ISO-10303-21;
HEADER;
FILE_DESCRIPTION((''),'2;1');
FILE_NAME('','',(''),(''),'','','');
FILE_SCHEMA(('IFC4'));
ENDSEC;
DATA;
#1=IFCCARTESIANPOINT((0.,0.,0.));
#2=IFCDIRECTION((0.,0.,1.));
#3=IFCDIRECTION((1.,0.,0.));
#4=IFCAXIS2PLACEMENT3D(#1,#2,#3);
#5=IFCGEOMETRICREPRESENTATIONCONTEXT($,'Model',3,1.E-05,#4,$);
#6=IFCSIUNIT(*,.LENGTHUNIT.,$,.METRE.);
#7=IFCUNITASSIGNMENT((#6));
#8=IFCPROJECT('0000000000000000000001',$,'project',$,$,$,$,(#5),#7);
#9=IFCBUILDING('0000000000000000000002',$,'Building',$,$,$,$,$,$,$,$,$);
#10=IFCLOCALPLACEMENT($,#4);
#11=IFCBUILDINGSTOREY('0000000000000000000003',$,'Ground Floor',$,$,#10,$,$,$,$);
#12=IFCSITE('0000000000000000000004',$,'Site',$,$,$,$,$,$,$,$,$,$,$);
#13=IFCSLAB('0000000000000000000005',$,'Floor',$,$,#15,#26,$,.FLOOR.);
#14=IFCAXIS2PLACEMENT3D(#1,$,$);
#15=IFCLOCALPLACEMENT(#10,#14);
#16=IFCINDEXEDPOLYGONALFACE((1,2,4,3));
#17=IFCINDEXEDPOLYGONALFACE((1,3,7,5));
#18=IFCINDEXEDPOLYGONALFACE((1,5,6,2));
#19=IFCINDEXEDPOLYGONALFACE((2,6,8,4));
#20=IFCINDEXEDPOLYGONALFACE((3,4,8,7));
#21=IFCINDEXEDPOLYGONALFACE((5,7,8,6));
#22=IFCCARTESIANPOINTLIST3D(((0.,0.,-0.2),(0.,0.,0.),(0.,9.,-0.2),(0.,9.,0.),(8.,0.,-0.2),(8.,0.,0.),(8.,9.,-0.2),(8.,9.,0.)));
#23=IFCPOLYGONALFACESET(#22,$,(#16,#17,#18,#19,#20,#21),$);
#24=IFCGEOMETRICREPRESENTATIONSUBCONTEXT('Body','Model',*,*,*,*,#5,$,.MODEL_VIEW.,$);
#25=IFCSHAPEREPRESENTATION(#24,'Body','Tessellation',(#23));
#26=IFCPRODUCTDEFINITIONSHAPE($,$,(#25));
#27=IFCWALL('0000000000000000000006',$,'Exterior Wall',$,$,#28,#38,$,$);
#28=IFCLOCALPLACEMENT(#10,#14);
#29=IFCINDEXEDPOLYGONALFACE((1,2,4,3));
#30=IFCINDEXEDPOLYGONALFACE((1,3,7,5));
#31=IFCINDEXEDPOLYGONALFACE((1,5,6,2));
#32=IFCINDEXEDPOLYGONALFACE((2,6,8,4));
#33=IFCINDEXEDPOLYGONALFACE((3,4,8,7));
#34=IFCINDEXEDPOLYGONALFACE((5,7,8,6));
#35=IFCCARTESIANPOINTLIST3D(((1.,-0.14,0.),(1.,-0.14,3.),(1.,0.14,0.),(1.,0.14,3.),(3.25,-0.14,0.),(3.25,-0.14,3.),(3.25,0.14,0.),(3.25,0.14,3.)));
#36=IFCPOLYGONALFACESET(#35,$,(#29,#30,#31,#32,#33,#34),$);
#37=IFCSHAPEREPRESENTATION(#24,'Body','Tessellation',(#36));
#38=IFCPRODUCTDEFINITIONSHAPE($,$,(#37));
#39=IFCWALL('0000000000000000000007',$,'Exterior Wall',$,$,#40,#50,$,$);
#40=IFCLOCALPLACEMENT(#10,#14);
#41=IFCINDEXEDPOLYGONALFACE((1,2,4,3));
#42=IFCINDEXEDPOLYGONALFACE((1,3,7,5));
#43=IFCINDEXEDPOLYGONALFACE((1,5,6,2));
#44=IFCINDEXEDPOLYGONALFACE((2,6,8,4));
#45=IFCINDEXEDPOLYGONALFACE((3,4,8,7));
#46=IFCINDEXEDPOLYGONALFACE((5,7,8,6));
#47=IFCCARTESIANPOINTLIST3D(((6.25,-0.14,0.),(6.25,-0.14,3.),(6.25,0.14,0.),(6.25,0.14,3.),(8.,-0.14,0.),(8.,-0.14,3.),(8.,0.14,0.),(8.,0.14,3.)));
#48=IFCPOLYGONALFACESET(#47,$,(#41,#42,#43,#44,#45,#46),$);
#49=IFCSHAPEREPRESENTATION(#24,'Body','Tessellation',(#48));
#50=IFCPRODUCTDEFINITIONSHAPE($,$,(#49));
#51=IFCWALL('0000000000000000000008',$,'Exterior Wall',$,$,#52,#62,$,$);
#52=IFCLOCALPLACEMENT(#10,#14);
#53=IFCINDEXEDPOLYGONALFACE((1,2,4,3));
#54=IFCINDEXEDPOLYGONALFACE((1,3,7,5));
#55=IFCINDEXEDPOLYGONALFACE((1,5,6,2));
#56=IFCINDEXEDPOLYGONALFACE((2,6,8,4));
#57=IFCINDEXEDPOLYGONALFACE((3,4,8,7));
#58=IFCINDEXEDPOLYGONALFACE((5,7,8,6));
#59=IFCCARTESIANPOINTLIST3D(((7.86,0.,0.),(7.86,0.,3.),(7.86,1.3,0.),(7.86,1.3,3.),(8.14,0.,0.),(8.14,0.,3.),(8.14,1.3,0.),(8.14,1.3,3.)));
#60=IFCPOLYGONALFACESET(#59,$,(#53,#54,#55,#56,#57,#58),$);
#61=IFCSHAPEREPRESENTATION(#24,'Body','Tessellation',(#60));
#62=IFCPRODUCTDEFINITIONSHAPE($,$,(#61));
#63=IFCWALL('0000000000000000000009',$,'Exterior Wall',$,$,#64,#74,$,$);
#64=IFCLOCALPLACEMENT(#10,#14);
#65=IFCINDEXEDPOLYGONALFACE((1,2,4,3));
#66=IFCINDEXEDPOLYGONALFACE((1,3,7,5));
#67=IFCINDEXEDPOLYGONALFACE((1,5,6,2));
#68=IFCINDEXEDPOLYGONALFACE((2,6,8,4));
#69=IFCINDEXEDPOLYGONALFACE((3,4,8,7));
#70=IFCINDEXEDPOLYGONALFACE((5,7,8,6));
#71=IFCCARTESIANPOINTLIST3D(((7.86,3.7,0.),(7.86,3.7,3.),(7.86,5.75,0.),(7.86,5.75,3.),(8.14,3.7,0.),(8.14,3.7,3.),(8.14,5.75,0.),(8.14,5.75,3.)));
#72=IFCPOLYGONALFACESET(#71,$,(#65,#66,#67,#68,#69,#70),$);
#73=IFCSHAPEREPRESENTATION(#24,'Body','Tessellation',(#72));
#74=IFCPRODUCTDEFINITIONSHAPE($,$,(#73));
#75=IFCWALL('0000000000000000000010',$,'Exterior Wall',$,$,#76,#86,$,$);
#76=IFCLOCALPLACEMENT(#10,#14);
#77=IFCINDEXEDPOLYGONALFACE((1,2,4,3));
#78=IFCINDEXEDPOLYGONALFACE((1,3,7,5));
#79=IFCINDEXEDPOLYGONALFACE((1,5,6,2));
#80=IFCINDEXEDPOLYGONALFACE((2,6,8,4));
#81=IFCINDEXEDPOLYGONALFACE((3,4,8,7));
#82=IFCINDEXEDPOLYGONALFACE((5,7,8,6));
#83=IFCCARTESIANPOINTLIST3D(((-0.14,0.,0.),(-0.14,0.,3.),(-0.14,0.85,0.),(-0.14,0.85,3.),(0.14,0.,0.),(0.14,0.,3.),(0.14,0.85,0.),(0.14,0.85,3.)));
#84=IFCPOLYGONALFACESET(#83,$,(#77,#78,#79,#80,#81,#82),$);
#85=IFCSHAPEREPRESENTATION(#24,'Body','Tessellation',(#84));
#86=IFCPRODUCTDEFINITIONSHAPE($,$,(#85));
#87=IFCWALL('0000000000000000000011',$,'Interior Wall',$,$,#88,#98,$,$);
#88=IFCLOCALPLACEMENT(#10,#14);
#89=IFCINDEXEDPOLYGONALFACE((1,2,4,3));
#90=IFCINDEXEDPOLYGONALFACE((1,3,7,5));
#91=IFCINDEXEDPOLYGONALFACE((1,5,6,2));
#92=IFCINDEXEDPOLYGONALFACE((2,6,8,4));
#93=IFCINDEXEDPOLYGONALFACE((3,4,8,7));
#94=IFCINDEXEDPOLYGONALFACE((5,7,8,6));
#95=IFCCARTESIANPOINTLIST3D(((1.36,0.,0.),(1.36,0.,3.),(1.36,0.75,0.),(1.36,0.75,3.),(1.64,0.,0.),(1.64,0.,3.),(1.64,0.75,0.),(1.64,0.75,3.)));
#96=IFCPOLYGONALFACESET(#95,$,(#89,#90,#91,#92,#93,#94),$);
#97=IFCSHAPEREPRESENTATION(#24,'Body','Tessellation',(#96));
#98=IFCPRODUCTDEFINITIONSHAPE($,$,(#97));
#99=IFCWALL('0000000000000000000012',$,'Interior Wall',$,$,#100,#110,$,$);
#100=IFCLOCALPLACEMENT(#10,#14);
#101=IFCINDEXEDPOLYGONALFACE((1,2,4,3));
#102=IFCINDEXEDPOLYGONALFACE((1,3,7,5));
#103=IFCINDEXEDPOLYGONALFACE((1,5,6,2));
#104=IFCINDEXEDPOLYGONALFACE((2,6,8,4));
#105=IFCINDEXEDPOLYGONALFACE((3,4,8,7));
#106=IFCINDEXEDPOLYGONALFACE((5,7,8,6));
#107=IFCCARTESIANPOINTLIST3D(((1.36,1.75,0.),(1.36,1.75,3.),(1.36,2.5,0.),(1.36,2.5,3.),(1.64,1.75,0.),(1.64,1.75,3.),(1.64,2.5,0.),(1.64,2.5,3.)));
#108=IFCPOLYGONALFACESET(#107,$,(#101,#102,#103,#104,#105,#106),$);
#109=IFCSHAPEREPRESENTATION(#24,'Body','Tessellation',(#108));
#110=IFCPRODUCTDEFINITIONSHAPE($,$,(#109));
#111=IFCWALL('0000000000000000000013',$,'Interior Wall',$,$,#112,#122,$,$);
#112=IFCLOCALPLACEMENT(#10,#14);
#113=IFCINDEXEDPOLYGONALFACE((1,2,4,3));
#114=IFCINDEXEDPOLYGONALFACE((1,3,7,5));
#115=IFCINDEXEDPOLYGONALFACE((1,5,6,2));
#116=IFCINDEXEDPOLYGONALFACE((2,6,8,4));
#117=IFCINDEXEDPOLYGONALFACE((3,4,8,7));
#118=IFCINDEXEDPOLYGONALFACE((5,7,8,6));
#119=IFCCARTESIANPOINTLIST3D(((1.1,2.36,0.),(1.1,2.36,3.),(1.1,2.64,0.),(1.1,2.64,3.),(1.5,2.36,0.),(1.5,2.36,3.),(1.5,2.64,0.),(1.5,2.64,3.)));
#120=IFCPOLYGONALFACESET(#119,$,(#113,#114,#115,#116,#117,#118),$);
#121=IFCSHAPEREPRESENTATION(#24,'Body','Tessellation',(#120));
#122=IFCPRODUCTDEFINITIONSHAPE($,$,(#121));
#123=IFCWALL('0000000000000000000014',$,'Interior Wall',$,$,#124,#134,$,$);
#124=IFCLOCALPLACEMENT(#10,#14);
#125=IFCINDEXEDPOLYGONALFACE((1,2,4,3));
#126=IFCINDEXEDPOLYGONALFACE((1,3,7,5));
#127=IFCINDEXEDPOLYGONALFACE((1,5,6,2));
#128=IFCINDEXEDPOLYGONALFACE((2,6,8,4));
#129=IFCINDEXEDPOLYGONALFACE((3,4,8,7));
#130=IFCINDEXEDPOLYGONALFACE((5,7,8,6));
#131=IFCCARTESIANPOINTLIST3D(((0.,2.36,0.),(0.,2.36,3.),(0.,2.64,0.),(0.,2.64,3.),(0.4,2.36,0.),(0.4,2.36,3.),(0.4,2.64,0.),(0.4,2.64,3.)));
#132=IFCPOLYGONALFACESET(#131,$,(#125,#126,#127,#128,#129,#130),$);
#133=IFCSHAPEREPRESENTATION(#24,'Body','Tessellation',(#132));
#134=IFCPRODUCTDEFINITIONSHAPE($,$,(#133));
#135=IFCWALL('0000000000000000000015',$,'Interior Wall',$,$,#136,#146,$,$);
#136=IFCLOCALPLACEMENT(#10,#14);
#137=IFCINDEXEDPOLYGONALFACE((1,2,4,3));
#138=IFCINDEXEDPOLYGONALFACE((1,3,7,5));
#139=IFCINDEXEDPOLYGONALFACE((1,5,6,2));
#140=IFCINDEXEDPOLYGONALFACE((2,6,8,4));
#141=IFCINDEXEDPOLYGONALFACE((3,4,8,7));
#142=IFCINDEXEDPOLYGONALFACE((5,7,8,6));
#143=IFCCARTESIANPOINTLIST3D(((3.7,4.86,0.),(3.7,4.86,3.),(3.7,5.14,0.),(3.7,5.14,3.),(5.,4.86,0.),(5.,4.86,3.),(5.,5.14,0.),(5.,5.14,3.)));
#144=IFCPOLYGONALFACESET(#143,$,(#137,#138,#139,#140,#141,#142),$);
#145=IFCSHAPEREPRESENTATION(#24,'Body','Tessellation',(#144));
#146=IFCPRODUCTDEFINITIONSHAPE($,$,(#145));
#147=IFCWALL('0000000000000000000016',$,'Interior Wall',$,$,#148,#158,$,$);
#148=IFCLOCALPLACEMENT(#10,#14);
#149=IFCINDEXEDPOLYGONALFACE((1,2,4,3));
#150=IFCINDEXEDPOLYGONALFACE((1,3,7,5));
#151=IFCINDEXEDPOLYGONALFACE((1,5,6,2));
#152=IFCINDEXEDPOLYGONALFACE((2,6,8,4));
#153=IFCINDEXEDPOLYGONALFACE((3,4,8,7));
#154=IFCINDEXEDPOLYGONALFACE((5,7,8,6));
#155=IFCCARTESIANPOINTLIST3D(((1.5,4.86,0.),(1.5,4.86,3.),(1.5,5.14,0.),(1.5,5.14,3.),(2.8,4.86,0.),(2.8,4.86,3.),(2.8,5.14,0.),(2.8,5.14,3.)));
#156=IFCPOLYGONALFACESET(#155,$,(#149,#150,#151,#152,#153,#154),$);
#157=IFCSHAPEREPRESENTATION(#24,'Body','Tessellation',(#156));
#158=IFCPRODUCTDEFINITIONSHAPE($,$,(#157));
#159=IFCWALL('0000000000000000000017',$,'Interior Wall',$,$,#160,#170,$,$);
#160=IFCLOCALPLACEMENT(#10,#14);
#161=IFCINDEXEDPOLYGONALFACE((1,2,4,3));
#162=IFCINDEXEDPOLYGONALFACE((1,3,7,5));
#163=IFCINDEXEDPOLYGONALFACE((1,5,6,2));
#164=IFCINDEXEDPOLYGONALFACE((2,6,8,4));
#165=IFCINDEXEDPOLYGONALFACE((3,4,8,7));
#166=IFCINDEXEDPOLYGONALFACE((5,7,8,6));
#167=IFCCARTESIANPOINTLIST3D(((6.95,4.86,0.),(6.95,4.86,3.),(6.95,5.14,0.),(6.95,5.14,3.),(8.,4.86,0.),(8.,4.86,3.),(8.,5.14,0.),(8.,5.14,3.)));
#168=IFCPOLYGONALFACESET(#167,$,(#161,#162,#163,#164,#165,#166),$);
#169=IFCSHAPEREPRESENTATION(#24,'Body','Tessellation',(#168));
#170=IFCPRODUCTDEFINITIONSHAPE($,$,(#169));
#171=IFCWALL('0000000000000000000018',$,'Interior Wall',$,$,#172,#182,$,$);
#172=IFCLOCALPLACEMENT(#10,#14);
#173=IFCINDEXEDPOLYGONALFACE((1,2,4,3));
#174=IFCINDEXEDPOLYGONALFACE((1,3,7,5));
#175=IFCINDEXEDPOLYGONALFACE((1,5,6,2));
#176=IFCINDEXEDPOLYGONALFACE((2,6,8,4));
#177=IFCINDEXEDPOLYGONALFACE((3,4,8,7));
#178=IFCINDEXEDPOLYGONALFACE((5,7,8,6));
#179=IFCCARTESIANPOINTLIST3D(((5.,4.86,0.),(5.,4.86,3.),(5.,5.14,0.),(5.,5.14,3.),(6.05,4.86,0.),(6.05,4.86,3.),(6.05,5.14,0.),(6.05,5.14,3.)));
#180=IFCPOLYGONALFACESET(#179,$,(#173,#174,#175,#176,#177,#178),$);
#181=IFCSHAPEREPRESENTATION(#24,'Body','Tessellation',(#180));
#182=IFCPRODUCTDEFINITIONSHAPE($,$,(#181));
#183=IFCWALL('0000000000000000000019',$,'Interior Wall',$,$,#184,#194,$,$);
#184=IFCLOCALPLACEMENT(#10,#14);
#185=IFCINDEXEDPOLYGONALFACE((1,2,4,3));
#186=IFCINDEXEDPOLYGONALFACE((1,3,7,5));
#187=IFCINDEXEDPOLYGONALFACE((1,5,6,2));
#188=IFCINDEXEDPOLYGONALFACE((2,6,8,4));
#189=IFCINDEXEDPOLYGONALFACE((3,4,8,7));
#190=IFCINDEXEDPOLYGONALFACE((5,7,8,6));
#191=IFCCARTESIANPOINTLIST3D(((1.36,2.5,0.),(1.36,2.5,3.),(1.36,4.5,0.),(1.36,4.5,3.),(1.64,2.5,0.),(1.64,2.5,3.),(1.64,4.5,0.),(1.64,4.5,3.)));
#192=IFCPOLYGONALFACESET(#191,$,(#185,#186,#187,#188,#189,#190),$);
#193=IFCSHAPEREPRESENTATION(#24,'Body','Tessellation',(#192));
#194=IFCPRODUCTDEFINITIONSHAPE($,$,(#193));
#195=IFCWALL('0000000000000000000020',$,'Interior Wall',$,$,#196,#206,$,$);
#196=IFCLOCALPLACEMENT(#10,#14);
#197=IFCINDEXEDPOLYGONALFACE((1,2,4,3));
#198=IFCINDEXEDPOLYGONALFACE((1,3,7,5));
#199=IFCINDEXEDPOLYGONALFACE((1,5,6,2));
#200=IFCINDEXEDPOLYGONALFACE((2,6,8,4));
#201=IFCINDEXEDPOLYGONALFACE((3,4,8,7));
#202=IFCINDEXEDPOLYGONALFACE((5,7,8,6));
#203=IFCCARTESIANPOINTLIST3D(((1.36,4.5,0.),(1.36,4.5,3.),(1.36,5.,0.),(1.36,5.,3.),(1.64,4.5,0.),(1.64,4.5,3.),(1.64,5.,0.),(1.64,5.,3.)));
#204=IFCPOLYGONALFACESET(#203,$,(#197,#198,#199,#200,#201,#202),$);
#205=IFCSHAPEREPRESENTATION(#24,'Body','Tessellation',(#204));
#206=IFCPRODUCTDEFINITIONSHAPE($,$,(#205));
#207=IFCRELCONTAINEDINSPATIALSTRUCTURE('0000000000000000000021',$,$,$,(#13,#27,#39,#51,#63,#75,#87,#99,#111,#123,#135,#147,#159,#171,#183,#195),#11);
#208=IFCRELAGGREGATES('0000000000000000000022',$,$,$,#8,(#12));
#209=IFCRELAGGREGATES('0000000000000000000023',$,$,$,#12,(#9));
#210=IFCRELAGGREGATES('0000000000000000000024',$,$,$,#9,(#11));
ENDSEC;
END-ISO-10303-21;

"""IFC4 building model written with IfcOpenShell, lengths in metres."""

from ifc_helpers import new_model, si_unit, frame, origin_with_axes, place, context, subcontext, project, spatial, indexed_curve, outline, extrude, element, save


model = new_model("IFC4")

# Units and contexts
model_context = context("Model", 3, precision=1e-05, world=origin_with_axes())
body_context = subcontext(model_context, "Body", "Model", "MODEL_VIEW")
ifc_project = project(units=[si_unit("LENGTHUNIT", "METRE")], contexts=[model_context])

# Site, building, storey
site = spatial("IfcSite", under=ifc_project, Name="Site")
building = spatial("IfcBuilding", under=site, Name="Building")
storey_placement = place(None, origin_with_axes())
storey = spatial("IfcBuildingStorey", under=building, at=storey_placement, Name="Ground Floor")

# Slab
slab_placement = place(storey_placement, frame((0.0, 0.0, -0.2), z_axis=(0.0, 0.0, 1.0), x_axis=(1.0, 0.0, 0.0)))
element("IfcSlab", 1, at=slab_placement, inside=storey, Name="Floor", PredefinedType="FLOOR", context=body_context, shape_type="SweptSolid", body=[
    extrude(outline(indexed_curve([(0.0, 0.0), (8.0, 0.0), (8.0, 9.0), (0.0, 9.0)])), None, (0.0, 0.0, 1.0), 0.2),
])

# Walls
wall_1_placement = place(storey_placement, frame((1.0, 0.0, 0.0), z_axis=(0.0, 0.0, 1.0), x_axis=(1.0, 0.0, 0.0)))
element("IfcWall", 2, at=wall_1_placement, inside=storey, Name="Exterior Wall", context=body_context, shape_type="SweptSolid", body=[
    extrude(outline(indexed_curve([(0.0, 0.0), (0.0, 0.28), (2.25, 0.28), (2.25, 0.0), (0.0, 0.0)], self_intersect=False)), frame((0.0, -0.14, 0.0), z_axis=(0.0, 0.0, 1.0), x_axis=(1.0, 0.0, 0.0)), (0.0, 0.0, 1.0), 3.0),
])
wall_2_placement = place(storey_placement, frame((6.25, 0.0, 0.0), z_axis=(0.0, 0.0, 1.0), x_axis=(1.0, 0.0, 0.0)))
element("IfcWall", 3, at=wall_2_placement, inside=storey, Name="Exterior Wall", context=body_context, shape_type="SweptSolid", body=[
    extrude(outline(indexed_curve([(0.0, 0.0), (0.0, 0.28), (1.75, 0.28), (1.75, 0.0), (0.0, 0.0)], self_intersect=False)), frame((0.0, -0.14, 0.0), z_axis=(0.0, 0.0, 1.0), x_axis=(1.0, 0.0, 0.0)), (0.0, 0.0, 1.0), 3.0),
])
wall_3_placement = place(storey_placement, frame((8.0, 0.0, 0.0), z_axis=(0.0, 0.0, 1.0), x_axis=(0.0, 1.0, 0.0)))
element("IfcWall", 4, at=wall_3_placement, inside=storey, Name="Exterior Wall", context=body_context, shape_type="SweptSolid", body=[
    extrude(outline(indexed_curve([(0.0, 0.0), (0.0, 0.28), (1.3, 0.28), (1.3, 0.0), (0.0, 0.0)], self_intersect=False)), frame((0.0, -0.14, 0.0), z_axis=(0.0, 0.0, 1.0), x_axis=(1.0, 0.0, 0.0)), (0.0, 0.0, 1.0), 3.0),
])
wall_4_placement = place(storey_placement, frame((8.0, 3.7, 0.0), z_axis=(0.0, 0.0, 1.0), x_axis=(0.0, 1.0, 0.0)))
element("IfcWall", 5, at=wall_4_placement, inside=storey, Name="Exterior Wall", context=body_context, shape_type="SweptSolid", body=[
    extrude(outline(indexed_curve([(0.0, 0.0), (0.0, 0.28), (2.05, 0.28), (2.05, 0.0), (0.0, 0.0)], self_intersect=False)), frame((0.0, -0.14, 0.0), z_axis=(0.0, 0.0, 1.0), x_axis=(1.0, 0.0, 0.0)), (0.0, 0.0, 1.0), 3.0),
])
wall_5_placement = place(storey_placement, frame((0.0, 0.85, 0.0), z_axis=(0.0, 0.0, 1.0), x_axis=(0.0, -1.0, 0.0)))
element("IfcWall", 6, at=wall_5_placement, inside=storey, Name="Exterior Wall", context=body_context, shape_type="SweptSolid", body=[
    extrude(outline(indexed_curve([(0.0, 0.0), (0.0, 0.28), (0.85, 0.28), (0.85, 0.0), (0.0, 0.0)], self_intersect=False)), frame((0.0, -0.14, 0.0), z_axis=(0.0, 0.0, 1.0), x_axis=(1.0, 0.0, 0.0)), (0.0, 0.0, 1.0), 3.0),
])
for number, where, z_axis, x_axis, name in (
    (7, (1.5, 0.0, 0.0), (0.0, 0.0, 1.0), (0.0, 1.0, 0.0), "Interior Wall"),
    (8, (1.5, 1.75, 0.0), (0.0, 0.0, 1.0), (0.0, 1.0, 0.0), "Interior Wall"),
):
    element("IfcWall", number, at=place(storey_placement, frame(where, z_axis=z_axis, x_axis=x_axis)), inside=storey, Name=name, context=body_context, shape_type="SweptSolid", body=[
        extrude(outline(indexed_curve([(0.0, 0.0), (0.0, 0.28), (0.75, 0.28), (0.75, 0.0), (0.0, 0.0)], self_intersect=False)), frame((0.0, -0.14, 0.0), z_axis=(0.0, 0.0, 1.0), x_axis=(1.0, 0.0, 0.0)), (0.0, 0.0, 1.0), 3.0),
    ])
for number, where, z_axis, x_axis, name in (
    (9, (1.5, 2.5, 0.0), (0.0, 0.0, 1.0), (-1.0, 0.0, 0.0), "Interior Wall"),
    (10, (0.4, 2.5, 0.0), (0.0, 0.0, 1.0), (-1.0, 0.0, 0.0), "Interior Wall"),
):
    element("IfcWall", number, at=place(storey_placement, frame(where, z_axis=z_axis, x_axis=x_axis)), inside=storey, Name=name, context=body_context, shape_type="SweptSolid", body=[
        extrude(outline(indexed_curve([(0.0, 0.0), (0.0, 0.28), (0.4, 0.28), (0.4, 0.0), (0.0, 0.0)], self_intersect=False)), frame((0.0, -0.14, 0.0), z_axis=(0.0, 0.0, 1.0), x_axis=(1.0, 0.0, 0.0)), (0.0, 0.0, 1.0), 3.0),
    ])
for number, where, z_axis, x_axis, name in (
    (11, (5.0, 5.0, 0.0), (0.0, 0.0, 1.0), (-1.0, 0.0, 0.0), "Interior Wall"),
    (12, (2.8, 5.0, 0.0), (0.0, 0.0, 1.0), (-1.0, 0.0, 0.0), "Interior Wall"),
):
    element("IfcWall", number, at=place(storey_placement, frame(where, z_axis=z_axis, x_axis=x_axis)), inside=storey, Name=name, context=body_context, shape_type="SweptSolid", body=[
        extrude(outline(indexed_curve([(0.0, 0.0), (0.0, 0.28), (1.3, 0.28), (1.3, 0.0), (0.0, 0.0)], self_intersect=False)), frame((0.0, -0.14, 0.0), z_axis=(0.0, 0.0, 1.0), x_axis=(1.0, 0.0, 0.0)), (0.0, 0.0, 1.0), 3.0),
    ])
for number, where, z_axis, x_axis, name in (
    (13, (8.0, 5.0, 0.0), (0.0, 0.0, 1.0), (-1.0, 0.0, 0.0), "Interior Wall"),
    (14, (6.05, 5.0, 0.0), (0.0, 0.0, 1.0), (-1.0, 0.0, 0.0), "Interior Wall"),
):
    element("IfcWall", number, at=place(storey_placement, frame(where, z_axis=z_axis, x_axis=x_axis)), inside=storey, Name=name, context=body_context, shape_type="SweptSolid", body=[
        extrude(outline(indexed_curve([(0.0, 0.0), (0.0, 0.28), (1.05, 0.28), (1.05, 0.0), (0.0, 0.0)], self_intersect=False)), frame((0.0, -0.14, 0.0), z_axis=(0.0, 0.0, 1.0), x_axis=(1.0, 0.0, 0.0)), (0.0, 0.0, 1.0), 3.0),
    ])
wall_6_placement = place(storey_placement, frame((1.5, 4.5, 0.0), z_axis=(0.0, 0.0, 1.0), x_axis=(0.0, -1.0, 0.0)))
element("IfcWall", 15, at=wall_6_placement, inside=storey, Name="Interior Wall", context=body_context, shape_type="SweptSolid", body=[
    extrude(outline(indexed_curve([(0.0, 0.0), (0.0, 0.28), (2.0, 0.28), (2.0, 0.0), (0.0, 0.0)], self_intersect=False)), frame((0.0, -0.14, 0.0), z_axis=(0.0, 0.0, 1.0), x_axis=(1.0, 0.0, 0.0)), (0.0, 0.0, 1.0), 3.0),
])
wall_7_placement = place(storey_placement, frame((1.5, 5.0, 0.0), z_axis=(0.0, 0.0, 1.0), x_axis=(0.0, -1.0, 0.0)))
element("IfcWall", 16, at=wall_7_placement, inside=storey, Name="Interior Wall", context=body_context, shape_type="SweptSolid", body=[
    extrude(outline(indexed_curve([(0.0, 0.0), (0.0, 0.28), (0.5, 0.28), (0.5, 0.0), (0.0, 0.0)], self_intersect=False)), frame((0.0, -0.14, 0.0), z_axis=(0.0, 0.0, 1.0), x_axis=(1.0, 0.0, 0.0)), (0.0, 0.0, 1.0), 3.0),
])

save(model, "model.ifc")
